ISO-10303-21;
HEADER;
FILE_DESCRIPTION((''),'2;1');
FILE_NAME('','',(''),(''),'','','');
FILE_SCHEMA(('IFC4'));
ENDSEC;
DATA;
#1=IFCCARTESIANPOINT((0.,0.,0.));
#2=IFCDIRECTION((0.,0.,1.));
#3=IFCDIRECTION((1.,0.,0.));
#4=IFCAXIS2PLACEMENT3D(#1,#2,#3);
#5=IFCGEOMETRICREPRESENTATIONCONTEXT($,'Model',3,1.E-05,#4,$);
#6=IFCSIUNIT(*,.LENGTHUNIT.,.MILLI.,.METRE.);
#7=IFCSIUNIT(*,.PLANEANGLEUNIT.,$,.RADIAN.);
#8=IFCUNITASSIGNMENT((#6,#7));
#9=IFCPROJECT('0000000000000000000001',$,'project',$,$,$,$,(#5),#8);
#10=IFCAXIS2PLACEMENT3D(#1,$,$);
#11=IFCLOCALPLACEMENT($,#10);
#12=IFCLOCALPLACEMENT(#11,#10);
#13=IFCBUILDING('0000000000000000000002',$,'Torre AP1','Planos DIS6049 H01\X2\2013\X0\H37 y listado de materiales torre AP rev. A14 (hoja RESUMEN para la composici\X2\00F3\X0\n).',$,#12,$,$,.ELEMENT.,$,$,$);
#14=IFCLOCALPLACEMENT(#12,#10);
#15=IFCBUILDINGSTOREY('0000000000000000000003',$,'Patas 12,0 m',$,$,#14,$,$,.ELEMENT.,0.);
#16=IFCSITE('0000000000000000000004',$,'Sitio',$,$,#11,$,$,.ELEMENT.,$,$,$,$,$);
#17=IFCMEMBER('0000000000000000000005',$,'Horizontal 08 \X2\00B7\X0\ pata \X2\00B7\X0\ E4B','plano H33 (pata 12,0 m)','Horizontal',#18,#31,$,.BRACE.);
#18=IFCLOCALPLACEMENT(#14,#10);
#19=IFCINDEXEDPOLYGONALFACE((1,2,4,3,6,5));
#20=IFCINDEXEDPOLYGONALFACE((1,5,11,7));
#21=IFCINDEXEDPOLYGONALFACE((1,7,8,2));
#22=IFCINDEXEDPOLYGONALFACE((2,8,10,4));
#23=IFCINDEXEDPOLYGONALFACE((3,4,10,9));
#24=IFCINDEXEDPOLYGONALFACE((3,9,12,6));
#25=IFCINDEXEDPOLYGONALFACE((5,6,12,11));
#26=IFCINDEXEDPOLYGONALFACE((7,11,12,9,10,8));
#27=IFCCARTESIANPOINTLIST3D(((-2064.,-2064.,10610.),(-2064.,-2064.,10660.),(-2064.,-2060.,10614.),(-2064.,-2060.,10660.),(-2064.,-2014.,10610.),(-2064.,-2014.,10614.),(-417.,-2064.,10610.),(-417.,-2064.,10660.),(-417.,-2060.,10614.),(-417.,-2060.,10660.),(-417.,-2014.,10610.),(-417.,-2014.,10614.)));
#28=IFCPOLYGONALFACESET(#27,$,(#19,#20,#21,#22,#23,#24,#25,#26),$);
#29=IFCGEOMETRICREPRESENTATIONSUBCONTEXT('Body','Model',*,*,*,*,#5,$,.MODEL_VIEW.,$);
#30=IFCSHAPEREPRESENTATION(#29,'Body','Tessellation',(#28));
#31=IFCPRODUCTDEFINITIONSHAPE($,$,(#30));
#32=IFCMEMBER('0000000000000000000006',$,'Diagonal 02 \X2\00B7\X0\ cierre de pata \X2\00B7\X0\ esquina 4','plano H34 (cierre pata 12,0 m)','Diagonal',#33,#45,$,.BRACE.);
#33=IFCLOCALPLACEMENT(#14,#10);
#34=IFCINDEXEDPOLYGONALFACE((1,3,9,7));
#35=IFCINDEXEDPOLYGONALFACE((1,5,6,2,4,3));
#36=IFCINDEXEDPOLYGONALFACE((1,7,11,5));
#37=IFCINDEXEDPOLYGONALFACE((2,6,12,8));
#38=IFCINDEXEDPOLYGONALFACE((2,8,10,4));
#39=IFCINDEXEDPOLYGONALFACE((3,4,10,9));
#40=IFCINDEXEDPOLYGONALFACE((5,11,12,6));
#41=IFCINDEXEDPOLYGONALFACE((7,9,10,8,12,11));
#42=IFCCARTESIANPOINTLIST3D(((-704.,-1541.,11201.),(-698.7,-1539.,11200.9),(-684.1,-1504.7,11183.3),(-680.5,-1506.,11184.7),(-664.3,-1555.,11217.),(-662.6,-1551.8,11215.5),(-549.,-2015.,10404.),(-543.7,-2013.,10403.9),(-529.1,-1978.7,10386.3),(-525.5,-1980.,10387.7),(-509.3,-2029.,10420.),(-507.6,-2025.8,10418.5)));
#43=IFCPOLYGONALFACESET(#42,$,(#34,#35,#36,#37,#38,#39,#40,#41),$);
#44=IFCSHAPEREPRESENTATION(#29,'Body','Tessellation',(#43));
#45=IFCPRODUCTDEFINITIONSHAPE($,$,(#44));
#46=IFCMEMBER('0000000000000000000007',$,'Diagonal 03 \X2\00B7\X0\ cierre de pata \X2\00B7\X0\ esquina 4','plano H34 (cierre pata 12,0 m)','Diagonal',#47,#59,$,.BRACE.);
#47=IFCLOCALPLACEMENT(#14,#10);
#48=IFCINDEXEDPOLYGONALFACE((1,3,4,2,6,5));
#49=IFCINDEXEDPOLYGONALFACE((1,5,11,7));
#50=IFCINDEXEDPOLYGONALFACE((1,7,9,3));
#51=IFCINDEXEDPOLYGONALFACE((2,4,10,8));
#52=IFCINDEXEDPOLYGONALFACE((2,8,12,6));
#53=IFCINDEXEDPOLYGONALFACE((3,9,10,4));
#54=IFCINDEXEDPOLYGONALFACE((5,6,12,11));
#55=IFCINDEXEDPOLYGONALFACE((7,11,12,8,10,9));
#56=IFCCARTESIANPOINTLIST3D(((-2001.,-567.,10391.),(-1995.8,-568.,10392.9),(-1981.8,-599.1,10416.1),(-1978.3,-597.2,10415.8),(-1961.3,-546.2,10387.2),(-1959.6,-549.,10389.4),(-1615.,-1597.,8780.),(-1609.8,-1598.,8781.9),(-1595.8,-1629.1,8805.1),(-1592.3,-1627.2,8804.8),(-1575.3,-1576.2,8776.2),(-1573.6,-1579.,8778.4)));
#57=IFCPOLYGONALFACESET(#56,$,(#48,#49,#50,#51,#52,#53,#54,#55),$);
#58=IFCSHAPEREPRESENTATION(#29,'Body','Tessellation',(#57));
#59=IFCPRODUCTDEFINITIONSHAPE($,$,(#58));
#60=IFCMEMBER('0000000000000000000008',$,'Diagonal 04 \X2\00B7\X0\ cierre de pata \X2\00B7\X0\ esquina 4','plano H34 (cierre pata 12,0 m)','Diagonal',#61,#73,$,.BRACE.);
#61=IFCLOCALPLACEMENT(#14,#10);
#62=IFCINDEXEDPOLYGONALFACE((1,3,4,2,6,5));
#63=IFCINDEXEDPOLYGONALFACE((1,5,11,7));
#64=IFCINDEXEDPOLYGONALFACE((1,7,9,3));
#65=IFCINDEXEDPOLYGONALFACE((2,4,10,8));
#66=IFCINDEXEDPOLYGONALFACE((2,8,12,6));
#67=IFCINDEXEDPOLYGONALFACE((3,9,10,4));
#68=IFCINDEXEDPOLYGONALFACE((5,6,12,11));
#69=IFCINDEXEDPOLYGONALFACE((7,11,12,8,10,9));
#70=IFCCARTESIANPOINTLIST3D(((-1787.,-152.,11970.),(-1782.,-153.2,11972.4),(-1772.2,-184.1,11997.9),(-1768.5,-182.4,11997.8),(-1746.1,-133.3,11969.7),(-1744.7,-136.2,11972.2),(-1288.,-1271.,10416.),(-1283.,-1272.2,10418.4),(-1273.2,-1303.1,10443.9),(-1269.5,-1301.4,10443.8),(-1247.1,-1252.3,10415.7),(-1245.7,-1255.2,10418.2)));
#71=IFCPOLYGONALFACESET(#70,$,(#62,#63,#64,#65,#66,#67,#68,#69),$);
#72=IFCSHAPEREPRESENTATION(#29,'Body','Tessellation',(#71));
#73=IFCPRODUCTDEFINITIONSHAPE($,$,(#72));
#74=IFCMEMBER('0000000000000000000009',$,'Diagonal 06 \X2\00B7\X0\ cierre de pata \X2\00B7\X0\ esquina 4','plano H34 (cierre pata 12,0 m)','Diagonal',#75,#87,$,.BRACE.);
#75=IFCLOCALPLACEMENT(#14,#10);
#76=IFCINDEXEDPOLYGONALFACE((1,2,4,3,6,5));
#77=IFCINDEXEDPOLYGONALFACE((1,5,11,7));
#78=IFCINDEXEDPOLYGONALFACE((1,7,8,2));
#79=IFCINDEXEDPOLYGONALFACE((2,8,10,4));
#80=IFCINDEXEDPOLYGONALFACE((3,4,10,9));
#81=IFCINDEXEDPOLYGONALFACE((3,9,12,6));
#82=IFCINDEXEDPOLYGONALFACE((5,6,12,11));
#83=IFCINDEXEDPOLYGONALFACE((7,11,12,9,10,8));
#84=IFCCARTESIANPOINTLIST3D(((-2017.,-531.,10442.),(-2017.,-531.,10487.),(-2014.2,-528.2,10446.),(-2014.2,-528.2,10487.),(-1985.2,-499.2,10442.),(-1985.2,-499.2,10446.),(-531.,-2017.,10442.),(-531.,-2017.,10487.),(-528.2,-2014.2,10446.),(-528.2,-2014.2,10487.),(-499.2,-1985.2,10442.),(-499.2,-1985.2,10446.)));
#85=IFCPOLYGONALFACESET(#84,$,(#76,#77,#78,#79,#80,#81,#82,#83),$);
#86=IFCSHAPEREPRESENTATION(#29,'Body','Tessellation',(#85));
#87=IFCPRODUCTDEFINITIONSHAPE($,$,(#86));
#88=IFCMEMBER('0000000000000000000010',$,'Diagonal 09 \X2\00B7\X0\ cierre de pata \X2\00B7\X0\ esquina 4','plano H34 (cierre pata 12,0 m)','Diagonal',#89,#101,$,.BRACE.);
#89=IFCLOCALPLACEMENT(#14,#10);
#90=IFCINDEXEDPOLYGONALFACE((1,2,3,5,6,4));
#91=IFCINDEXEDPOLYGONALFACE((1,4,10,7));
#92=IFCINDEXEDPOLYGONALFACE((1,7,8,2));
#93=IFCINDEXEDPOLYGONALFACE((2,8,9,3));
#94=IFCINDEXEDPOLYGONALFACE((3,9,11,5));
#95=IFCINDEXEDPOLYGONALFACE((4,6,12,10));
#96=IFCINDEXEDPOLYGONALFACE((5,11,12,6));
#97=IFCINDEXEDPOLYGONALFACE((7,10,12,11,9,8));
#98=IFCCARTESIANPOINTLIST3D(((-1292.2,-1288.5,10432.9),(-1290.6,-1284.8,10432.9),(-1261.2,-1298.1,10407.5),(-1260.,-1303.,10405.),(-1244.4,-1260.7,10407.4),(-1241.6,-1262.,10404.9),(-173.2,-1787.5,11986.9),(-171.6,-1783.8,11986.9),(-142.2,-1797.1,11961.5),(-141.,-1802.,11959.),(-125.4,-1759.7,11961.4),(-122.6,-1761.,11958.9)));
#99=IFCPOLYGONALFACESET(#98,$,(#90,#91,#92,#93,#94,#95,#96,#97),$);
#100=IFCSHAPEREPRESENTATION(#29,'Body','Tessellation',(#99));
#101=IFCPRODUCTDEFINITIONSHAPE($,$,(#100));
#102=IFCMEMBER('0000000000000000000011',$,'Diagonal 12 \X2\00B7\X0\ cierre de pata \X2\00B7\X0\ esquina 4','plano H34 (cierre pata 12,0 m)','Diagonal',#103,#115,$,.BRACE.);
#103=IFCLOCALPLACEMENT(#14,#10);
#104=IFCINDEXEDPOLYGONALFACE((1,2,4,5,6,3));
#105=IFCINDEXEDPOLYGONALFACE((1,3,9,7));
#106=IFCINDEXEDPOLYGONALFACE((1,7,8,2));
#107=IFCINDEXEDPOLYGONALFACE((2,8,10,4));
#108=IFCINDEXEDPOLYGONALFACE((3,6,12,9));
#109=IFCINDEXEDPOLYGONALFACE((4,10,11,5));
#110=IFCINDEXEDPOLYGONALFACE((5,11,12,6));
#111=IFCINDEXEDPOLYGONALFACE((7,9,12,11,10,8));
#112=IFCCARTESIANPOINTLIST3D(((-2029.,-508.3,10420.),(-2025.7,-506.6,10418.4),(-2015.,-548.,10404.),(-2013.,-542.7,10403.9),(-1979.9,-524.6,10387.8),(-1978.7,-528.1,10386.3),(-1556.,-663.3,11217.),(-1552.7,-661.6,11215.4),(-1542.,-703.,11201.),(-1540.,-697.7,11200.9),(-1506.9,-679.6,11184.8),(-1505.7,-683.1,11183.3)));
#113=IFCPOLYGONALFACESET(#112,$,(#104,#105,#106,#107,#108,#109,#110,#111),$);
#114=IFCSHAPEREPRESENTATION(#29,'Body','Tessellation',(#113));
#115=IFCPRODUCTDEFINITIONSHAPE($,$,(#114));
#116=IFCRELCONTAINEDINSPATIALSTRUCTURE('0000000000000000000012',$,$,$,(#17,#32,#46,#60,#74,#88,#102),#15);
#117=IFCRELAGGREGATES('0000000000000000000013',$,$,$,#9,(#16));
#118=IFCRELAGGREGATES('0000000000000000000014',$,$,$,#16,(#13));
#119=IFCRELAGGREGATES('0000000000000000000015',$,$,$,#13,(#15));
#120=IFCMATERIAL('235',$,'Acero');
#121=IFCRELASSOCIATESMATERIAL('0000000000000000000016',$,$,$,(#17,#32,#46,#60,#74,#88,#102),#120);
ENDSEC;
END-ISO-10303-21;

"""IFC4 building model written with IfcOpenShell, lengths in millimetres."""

from ifc_helpers import new_model, si_unit, frame, frame_2d, origin, origin_with_axes, place, context, subcontext, project, spatial, l_section, extrude, material, element, save


model = new_model("IFC4")

# Units and contexts
model_context = context("Model", 3, precision=1e-05, world=origin_with_axes())
body_context = subcontext(model_context, "Body", "Model", "MODEL_VIEW")
ifc_project = project(units=[si_unit("LENGTHUNIT", "METRE", prefix="MILLI"), si_unit("PLANEANGLEUNIT", "RADIAN")], contexts=[model_context])

# Site, building, storey
site_placement = place(None, origin())
site = spatial("IfcSite", under=ifc_project, at=site_placement, Name="Sitio", CompositionType="ELEMENT")
building_placement = place(site_placement, origin())
building = spatial("IfcBuilding", under=site, at=building_placement, Name="Torre AP1", Description="Planos DIS6049 H01–H37 y listado de materiales torre AP rev. A14 (hoja RESUMEN para la composición).", CompositionType="ELEMENT")
storey_placement = place(building_placement, origin())
storey = spatial("IfcBuildingStorey", under=building, at=storey_placement, Name="Patas 12,0 m", CompositionType="ELEMENT", Elevation=0.0)

# Members
ifc_material_1 = material(Name="235", Category="Acero")
for number, where, z_axis, x_axis, name in (
    (1, (-2064.0, -2064.0, 10610.0), (1.0, 0.0, 0.0), (0.0, 1.0, 0.0), "Horizontal 08 · pata · E4B"),
):
    element("IfcMember", number, at=place(storey_placement, frame(where, z_axis=z_axis, x_axis=x_axis)), inside=storey, material=ifc_material_1, Name=name, Description="plano H33 (pata 12,0 m)", ObjectType="Horizontal", PredefinedType="BRACE", context=body_context, shape_type="SweptSolid", body=[
        extrude(l_section(Depth=50.0, Width=50.0, Thickness=4.0, at=frame_2d((25.0, 25.0))), None, (0.0, 0.0, 1.0), 1647.0),
    ])
member_1_placement = place(storey_placement, frame((-704.0, -1541.0, 11201.0), z_axis=(0.164865, -0.504167, -0.847724), x_axis=(0.442792, 0.805838, -0.393142)))
element("IfcMember", 2, at=member_1_placement, inside=storey, material=ifc_material_1, Name="Diagonal 02 · cierre de pata · esquina 4", Description="plano H34 (cierre pata 12,0 m)", ObjectType="Diagonal", PredefinedType="BRACE", context=body_context, shape_type="SweptSolid", body=[
    extrude(l_section(Depth=45.0, Width=45.0, Thickness=4.0, at=frame_2d((22.5, 22.5))), None, (0.0, 0.0, 1.0), 940.2),
])
member_2_placement = place(storey_placement, frame((-2001.0, -567.0, 10391.0), z_axis=(0.197878, -0.528017, -0.825859), x_axis=(0.882679, 0.462384, -0.084135)))
element("IfcMember", 3, at=member_2_placement, inside=storey, material=ifc_material_1, Name="Diagonal 03 · cierre de pata · esquina 4", Description="plano H34 (cierre pata 12,0 m)", ObjectType="Diagonal", PredefinedType="BRACE", context=body_context, shape_type="SweptSolid", body=[
    extrude(l_section(Depth=45.0, Width=45.0, Thickness=4.0, at=frame_2d((22.5, 22.5))), None, (0.0, 0.0, 1.0), 1950.7),
])
member_3_placement = place(storey_placement, frame((-1787.0, -152.0, 11970.0), z_axis=(0.252159, -0.565463, -0.785281), x_axis=(0.909747, 0.415107, -0.006783)))
element("IfcMember", 4, at=member_3_placement, inside=storey, material=ifc_material_1, Name="Diagonal 04 · cierre de pata · esquina 4", Description="plano H34 (cierre pata 12,0 m)", ObjectType="Diagonal", PredefinedType="BRACE", context=body_context, shape_type="SweptSolid", body=[
    extrude(l_section(Depth=45.0, Width=45.0, Thickness=4.0, at=frame_2d((22.5, 22.5))), None, (0.0, 0.0, 1.0), 1978.9),
])
member_4_placement = place(storey_placement, frame((-2017.0, -531.0, 10442.0), z_axis=(0.707107, -0.707107, 0.0), x_axis=(0.707107, 0.707107, 0.0)))
element("IfcMember", 5, at=member_4_placement, inside=storey, material=ifc_material_1, Name="Diagonal 06 · cierre de pata · esquina 4", Description="plano H34 (cierre pata 12,0 m)", ObjectType="Diagonal", PredefinedType="BRACE", context=body_context, shape_type="SweptSolid", body=[
    extrude(l_section(Depth=45.0, Width=45.0, Thickness=4.0, at=frame_2d((22.5, 22.5))), None, (0.0, 0.0, 1.0), 2101.5),
])
member_5_placement = place(storey_placement, frame((-1260.0, -1303.0, 10405.0), z_axis=(0.565463, -0.252159, 0.785281), x_axis=(0.409744, 0.912198, -0.002135)))
element("IfcMember", 6, at=member_5_placement, inside=storey, material=ifc_material_1, Name="Diagonal 09 · cierre de pata · esquina 4", Description="plano H34 (cierre pata 12,0 m)", ObjectType="Diagonal", PredefinedType="BRACE", context=body_context, shape_type="SweptSolid", body=[
    extrude(l_section(Depth=45.0, Width=45.0, Thickness=4.0, at=frame_2d((22.5, 22.5))), None, (0.0, 0.0, 1.0), 1978.9),
])
member_6_placement = place(storey_placement, frame((-2015.0, -548.0, 10404.0), z_axis=(0.503373, -0.164953, 0.848178), x_axis=(0.806505, 0.441981, -0.392685)))
element("IfcMember", 7, at=member_6_placement, inside=storey, material=ifc_material_1, Name="Diagonal 12 · cierre de pata · esquina 4", Description="plano H34 (cierre pata 12,0 m)", ObjectType="Diagonal", PredefinedType="BRACE", context=body_context, shape_type="SweptSolid", body=[
    extrude(l_section(Depth=45.0, Width=45.0, Thickness=4.0, at=frame_2d((22.5, 22.5))), None, (0.0, 0.0, 1.0), 939.7),
])

save(model, "model.ifc")
